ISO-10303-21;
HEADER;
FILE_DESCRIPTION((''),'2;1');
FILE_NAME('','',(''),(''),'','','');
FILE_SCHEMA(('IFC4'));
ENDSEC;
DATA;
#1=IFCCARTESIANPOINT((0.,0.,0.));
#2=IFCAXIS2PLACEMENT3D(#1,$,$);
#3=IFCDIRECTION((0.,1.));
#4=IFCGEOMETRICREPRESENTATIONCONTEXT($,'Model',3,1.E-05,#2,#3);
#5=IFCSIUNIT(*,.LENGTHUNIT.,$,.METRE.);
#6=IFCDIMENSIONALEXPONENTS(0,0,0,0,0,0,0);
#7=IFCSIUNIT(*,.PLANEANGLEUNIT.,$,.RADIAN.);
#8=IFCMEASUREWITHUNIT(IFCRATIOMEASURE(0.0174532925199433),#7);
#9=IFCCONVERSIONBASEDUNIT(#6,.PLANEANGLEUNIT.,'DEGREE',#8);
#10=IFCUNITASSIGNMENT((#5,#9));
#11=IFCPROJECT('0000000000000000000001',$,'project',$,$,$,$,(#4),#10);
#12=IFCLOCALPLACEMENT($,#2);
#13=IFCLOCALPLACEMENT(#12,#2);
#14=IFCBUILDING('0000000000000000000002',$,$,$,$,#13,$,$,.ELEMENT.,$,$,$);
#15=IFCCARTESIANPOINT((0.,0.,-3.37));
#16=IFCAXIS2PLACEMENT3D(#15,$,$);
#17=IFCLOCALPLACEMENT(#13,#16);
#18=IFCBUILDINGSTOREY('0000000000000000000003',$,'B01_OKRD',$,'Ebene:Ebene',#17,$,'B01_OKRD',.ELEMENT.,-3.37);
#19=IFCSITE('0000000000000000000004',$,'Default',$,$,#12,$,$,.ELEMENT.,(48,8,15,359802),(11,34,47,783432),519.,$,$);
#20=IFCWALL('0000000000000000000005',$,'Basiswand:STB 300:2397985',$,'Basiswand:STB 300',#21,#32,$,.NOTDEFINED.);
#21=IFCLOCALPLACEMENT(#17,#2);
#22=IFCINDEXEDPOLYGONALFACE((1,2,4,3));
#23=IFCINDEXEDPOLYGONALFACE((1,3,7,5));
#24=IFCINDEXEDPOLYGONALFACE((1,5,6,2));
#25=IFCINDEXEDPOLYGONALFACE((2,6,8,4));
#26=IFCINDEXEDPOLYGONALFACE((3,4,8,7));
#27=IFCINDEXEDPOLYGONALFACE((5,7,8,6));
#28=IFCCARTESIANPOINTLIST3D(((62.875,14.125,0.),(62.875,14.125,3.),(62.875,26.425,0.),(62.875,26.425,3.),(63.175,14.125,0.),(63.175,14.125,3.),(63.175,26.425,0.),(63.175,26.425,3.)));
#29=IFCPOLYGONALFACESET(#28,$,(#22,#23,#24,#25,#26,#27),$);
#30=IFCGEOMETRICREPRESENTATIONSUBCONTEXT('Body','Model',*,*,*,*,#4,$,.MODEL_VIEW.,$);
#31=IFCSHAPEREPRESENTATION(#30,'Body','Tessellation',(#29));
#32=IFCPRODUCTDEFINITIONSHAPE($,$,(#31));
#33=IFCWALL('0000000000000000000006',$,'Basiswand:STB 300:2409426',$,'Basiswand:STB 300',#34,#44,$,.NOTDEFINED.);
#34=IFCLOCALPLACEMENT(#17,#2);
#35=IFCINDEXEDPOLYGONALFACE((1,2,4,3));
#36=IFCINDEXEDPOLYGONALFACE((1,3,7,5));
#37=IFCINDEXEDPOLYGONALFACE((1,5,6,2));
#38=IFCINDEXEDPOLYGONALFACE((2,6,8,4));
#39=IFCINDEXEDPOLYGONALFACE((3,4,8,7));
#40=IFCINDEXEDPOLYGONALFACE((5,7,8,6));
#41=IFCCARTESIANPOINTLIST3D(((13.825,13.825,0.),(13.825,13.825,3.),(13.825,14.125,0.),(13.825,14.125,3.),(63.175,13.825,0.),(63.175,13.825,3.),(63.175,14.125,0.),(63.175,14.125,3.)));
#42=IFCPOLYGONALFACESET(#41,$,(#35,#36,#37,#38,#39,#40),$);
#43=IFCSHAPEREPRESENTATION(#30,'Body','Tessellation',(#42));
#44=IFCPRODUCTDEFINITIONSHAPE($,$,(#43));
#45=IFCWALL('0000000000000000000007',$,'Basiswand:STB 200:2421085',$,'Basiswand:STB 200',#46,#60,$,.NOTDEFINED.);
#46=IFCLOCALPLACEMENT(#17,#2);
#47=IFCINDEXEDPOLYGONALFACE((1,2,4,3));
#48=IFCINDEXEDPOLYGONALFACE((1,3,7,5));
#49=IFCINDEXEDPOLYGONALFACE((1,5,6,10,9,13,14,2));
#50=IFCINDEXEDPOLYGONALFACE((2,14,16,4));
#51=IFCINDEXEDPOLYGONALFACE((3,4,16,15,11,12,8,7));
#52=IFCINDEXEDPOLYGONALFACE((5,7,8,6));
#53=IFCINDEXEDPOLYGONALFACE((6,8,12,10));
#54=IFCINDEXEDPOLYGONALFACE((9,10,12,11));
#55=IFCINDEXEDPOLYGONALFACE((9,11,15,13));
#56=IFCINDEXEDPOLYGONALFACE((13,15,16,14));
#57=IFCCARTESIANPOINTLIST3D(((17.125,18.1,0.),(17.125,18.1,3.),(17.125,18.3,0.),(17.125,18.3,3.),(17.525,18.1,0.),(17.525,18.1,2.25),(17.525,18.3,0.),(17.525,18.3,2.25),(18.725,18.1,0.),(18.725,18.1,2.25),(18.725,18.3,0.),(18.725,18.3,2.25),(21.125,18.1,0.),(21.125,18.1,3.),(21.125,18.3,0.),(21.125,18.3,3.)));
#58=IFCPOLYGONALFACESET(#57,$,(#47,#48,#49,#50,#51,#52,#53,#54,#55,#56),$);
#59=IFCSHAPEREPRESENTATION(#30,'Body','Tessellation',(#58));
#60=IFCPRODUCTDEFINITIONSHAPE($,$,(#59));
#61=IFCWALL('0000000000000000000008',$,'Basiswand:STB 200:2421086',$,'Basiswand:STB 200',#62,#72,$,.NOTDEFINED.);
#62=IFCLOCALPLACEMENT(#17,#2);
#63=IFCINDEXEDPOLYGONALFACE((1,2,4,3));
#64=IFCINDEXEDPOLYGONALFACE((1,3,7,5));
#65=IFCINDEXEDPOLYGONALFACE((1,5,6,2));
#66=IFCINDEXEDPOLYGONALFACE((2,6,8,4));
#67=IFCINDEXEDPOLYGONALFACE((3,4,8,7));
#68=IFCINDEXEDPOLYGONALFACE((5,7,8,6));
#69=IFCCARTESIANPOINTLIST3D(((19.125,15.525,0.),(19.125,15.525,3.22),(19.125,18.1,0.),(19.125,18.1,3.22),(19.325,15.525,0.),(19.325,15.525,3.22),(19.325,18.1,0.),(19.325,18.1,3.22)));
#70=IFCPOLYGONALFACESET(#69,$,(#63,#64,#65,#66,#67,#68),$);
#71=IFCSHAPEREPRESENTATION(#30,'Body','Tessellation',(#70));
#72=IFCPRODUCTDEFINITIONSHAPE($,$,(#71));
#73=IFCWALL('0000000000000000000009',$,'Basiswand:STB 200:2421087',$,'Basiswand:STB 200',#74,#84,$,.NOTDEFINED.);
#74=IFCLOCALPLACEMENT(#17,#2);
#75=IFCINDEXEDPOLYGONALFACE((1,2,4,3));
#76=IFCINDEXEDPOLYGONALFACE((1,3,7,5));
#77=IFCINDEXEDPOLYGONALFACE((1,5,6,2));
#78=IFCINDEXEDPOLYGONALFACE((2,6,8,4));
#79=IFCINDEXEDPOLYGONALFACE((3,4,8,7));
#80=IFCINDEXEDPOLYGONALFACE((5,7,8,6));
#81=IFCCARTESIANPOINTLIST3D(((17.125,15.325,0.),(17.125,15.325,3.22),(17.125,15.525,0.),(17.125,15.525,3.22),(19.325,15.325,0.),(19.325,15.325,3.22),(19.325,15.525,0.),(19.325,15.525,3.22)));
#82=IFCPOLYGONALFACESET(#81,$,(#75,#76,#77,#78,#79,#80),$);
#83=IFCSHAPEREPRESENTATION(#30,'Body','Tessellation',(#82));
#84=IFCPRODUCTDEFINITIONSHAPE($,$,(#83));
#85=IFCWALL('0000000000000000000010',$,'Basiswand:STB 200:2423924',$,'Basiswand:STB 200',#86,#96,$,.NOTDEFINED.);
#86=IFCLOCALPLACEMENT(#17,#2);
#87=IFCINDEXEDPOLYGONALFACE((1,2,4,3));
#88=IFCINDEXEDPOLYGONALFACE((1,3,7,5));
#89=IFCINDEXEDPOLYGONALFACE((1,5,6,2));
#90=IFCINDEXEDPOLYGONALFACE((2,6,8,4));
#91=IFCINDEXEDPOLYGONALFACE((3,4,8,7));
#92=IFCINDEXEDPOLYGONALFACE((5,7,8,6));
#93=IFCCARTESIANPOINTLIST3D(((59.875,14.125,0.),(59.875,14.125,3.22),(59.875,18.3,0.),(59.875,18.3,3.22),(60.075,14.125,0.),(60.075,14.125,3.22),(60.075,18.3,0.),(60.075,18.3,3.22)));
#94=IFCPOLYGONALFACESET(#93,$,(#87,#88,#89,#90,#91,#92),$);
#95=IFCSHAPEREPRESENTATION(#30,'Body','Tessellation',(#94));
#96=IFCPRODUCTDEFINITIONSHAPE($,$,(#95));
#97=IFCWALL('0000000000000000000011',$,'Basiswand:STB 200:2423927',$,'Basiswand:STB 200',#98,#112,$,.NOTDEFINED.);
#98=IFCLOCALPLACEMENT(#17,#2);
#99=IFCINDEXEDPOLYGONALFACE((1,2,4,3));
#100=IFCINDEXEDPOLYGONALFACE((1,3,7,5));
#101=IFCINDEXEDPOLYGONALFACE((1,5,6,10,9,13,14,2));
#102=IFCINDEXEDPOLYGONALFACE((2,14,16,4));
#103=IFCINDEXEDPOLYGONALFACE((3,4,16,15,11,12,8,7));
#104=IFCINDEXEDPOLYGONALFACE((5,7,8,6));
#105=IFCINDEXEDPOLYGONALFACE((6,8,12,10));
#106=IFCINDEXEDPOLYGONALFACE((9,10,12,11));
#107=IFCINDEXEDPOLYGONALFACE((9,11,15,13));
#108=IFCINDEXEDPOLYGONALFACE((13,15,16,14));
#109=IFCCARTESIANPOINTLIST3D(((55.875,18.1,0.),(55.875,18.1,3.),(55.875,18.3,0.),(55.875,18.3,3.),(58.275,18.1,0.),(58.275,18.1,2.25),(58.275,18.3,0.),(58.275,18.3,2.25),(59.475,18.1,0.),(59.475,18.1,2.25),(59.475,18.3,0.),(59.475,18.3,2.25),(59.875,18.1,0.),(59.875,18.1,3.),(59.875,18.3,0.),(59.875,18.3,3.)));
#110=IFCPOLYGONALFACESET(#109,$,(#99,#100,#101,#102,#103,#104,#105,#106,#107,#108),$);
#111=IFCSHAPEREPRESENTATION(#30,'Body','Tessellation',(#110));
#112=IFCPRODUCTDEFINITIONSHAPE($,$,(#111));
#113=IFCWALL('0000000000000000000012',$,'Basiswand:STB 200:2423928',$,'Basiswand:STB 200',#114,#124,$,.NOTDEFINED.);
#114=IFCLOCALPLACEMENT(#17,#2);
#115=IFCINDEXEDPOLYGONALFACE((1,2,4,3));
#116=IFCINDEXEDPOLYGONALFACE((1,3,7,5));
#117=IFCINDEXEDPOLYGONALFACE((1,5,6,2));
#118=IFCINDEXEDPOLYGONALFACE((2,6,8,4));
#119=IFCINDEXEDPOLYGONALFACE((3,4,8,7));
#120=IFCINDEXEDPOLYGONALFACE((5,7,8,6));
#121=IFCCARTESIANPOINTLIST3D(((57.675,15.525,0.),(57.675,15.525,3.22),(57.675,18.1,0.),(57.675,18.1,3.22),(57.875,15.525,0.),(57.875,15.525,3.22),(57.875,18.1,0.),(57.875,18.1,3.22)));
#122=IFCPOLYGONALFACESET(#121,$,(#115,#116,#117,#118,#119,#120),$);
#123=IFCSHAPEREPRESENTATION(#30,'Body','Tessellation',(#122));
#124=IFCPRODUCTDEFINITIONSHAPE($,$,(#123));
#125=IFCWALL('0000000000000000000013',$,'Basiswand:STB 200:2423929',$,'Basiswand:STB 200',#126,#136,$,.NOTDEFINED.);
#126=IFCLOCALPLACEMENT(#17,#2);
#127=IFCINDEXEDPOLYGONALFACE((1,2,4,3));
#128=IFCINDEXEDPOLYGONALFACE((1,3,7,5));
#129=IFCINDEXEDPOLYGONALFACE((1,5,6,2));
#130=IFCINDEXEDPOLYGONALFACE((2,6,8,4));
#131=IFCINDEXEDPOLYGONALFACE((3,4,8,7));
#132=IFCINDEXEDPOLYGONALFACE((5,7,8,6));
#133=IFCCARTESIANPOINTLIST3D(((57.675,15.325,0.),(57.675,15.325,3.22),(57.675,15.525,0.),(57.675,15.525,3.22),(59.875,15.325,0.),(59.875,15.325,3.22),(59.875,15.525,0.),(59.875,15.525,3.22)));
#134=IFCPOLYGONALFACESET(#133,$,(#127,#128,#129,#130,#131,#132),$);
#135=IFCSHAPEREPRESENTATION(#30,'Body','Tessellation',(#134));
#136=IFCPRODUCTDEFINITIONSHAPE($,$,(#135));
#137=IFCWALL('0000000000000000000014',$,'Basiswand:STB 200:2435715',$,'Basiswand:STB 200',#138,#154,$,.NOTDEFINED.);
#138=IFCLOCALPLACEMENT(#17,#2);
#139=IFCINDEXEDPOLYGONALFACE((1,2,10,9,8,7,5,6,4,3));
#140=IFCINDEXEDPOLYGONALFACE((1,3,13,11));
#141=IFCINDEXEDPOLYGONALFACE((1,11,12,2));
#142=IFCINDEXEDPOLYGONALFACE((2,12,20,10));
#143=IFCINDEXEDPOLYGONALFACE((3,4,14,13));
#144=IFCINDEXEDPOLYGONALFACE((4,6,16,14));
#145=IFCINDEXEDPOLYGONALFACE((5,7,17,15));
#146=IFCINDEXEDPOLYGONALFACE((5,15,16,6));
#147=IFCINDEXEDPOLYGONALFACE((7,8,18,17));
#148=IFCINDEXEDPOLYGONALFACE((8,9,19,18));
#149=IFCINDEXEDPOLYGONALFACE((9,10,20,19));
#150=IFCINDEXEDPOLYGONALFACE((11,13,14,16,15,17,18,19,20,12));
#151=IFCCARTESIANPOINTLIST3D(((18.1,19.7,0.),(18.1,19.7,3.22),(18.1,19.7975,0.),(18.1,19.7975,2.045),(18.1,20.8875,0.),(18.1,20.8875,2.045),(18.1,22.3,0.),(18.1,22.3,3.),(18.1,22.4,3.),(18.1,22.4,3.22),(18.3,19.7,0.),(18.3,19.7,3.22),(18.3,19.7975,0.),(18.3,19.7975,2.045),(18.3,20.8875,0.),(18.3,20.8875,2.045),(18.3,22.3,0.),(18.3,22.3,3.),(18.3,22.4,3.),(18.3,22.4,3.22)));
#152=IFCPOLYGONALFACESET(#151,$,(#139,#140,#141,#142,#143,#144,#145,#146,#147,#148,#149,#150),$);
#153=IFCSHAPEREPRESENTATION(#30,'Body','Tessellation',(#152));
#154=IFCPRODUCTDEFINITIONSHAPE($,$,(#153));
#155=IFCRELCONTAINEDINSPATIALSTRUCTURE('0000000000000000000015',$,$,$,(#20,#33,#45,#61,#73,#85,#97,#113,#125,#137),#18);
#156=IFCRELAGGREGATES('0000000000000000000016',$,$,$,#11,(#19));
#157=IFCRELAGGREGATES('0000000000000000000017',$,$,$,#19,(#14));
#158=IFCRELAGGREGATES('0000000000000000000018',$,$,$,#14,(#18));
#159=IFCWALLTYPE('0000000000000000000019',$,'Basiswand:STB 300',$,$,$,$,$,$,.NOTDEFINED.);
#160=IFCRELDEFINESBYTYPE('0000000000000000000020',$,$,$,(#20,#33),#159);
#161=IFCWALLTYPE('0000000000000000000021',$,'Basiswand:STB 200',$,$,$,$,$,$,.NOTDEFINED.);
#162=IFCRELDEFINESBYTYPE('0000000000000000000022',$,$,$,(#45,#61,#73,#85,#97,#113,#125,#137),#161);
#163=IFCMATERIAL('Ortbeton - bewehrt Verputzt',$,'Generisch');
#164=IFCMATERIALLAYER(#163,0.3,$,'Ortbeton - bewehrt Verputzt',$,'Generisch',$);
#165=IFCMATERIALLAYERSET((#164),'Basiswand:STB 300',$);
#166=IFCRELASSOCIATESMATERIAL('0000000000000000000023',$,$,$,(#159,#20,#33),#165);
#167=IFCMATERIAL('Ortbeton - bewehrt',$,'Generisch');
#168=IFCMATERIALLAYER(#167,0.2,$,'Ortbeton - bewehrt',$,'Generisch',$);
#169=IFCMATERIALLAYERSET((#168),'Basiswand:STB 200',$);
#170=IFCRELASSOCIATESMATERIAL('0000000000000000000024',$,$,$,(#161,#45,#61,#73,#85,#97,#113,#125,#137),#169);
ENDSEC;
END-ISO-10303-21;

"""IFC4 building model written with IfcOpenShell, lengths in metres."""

from ifc_helpers import new_model, entity, si_unit, converted_unit, direction, frame, frame_2d, origin, place, context, subcontext, project, spatial, polyline, rectangle, extrude, clip, bounded_halfspace, material, layer, layer_set, layer_usage, type_object, element, save


model = new_model("IFC4")

# Units and contexts
model_context = context("Model", 3, precision=1e-05, world=origin(), true_north=direction((0.0, 1.0)))
body_context = subcontext(model_context, "Body", "Model", "MODEL_VIEW")
ifc_project = project(units=[si_unit("LENGTHUNIT", "METRE"), converted_unit("PLANEANGLEUNIT", "DEGREE", entity("IfcRatioMeasure", 0.0174532925199433), si_unit("PLANEANGLEUNIT", "RADIAN"), dimensions=[0, 0, 0, 0, 0, 0, 0])], contexts=[model_context])

# Site, building, storey
site_placement = place(None, frame((0.0, 0.0, 0.0)))
site = spatial("IfcSite", under=ifc_project, at=site_placement, Name="Default", CompositionType="ELEMENT", RefLatitude=(48, 8, 15, 359802), RefLongitude=(11, 34, 47, 783432), RefElevation=519.0)
building_placement = place(site_placement, origin())
building = spatial("IfcBuilding", under=site, at=building_placement, CompositionType="ELEMENT")
storey_placement = place(building_placement, frame((0.0, 0.0, -3.37)))
storey = spatial("IfcBuildingStorey", under=building, at=storey_placement, Name="B01_OKRD", ObjectType="Ebene:Ebene", LongName="B01_OKRD", CompositionType="ELEMENT", Elevation=-3.37)

# Walls
ifc_material_1 = material(Name="Ortbeton - bewehrt Verputzt", Category="Generisch")
ifc_layer_1 = layer(ifc_material_1, 0.3, Name="Ortbeton - bewehrt Verputzt", Category="Generisch")
ifc_layer_set_1 = layer_set([ifc_layer_1], Name="Basiswand:STB 300")
ifc_layer_usage_1 = layer_usage(ifc_layer_set_1, "AXIS2", "NEGATIVE", 0.15)
wall_type_1 = type_object("IfcWallType", Name="Basiswand:STB 300", PredefinedType="NOTDEFINED", material=ifc_layer_set_1)
wall_1_placement = place(storey_placement, frame((63.025, 26.425, 0.0), z_axis=(0.0, 0.0, 1.0), x_axis=(0.0, -1.0, 0.0)))
element("IfcWall", 1, at=wall_1_placement, inside=storey, type_object=wall_type_1, material=ifc_layer_usage_1, Name="Basiswand:STB 300:2397985", ObjectType="Basiswand:STB 300", PredefinedType="NOTDEFINED", context=body_context, shape_type="SweptSolid", body=[
    extrude(rectangle(XDim=12.3, YDim=0.3, at=frame_2d((6.15, 0.0), x_axis=(-1.0, 0.0))), origin(), (0.0, 0.0, 1.0), 3.0),
])
ifc_layer_usage_2 = layer_usage(ifc_layer_set_1, "AXIS2", "NEGATIVE", 0.15)
wall_2_placement = place(storey_placement, frame((63.175, 13.975, 0.0), z_axis=(0.0, 0.0, 1.0), x_axis=(-1.0, 0.0, 0.0)))
element("IfcWall", 2, at=wall_2_placement, inside=storey, type_object=wall_type_1, material=ifc_layer_usage_2, Name="Basiswand:STB 300:2409426", ObjectType="Basiswand:STB 300", PredefinedType="NOTDEFINED", context=body_context, shape_type="SweptSolid", body=[
    extrude(rectangle(XDim=49.35, YDim=0.3, at=frame_2d((24.675, 0.0), x_axis=(-1.0, 0.0))), origin(), (0.0, 0.0, 1.0), 3.0),
])

# Wall, opening
ifc_material_2 = material(Name="Ortbeton - bewehrt", Category="Generisch")
ifc_layer_2 = layer(ifc_material_2, 0.2, Name="Ortbeton - bewehrt", Category="Generisch")
ifc_layer_set_2 = layer_set([ifc_layer_2], Name="Basiswand:STB 200")
ifc_layer_usage_3 = layer_usage(ifc_layer_set_2, "AXIS2", "POSITIVE", -0.1)
wall_type_2 = type_object("IfcWallType", Name="Basiswand:STB 200", PredefinedType="NOTDEFINED", material=ifc_layer_set_2)
wall_3_placement = place(storey_placement, frame((17.125, 18.2, 0.0)))
wall_3 = element("IfcWall", 3, at=wall_3_placement, inside=storey, type_object=wall_type_2, material=ifc_layer_usage_3, Name="Basiswand:STB 200:2421085", ObjectType="Basiswand:STB 200", PredefinedType="NOTDEFINED", context=body_context, shape_type="SweptSolid", body=[
    extrude(rectangle(XDim=4.0, YDim=0.2, at=frame_2d((2.0, 0.0), x_axis=(-1.0, 0.0))), origin(), (0.0, 0.0, 1.0), 3.0),
])
opening_1_placement = place(wall_3_placement, frame((0.4, -0.1, -0.03)))
element("IfcOpeningElement", 4, at=opening_1_placement, cuts=wall_3, ObjectType="Opening", PredefinedType="OPENING", context=body_context, shape_type="SweptSolid", body=[
    extrude(rectangle(XDim=2.28, YDim=1.2, at=frame_2d((1.14, 0.6), x_axis=(1.0, 0.0))), frame((0.0, 0.0, 0.0), z_axis=(0.0, 1.0, 0.0), x_axis=(0.0, 0.0, 1.0)), (0.0, 0.0, 1.0), 0.2),
])

# Walls
ifc_layer_usage_4 = layer_usage(ifc_layer_set_2, "AXIS2", "NEGATIVE", 0.1)
wall_4_placement = place(storey_placement, frame((19.225, 15.525, 0.0), z_axis=(0.0, 0.0, 1.0), x_axis=(0.0, 1.0, 0.0)))
element("IfcWall", 5, at=wall_4_placement, inside=storey, type_object=wall_type_2, material=ifc_layer_usage_4, Name="Basiswand:STB 200:2421086", ObjectType="Basiswand:STB 200", PredefinedType="NOTDEFINED", context=body_context, shape_type="SweptSolid", body=[
    extrude(rectangle(XDim=2.575, YDim=0.2, at=frame_2d((1.2875, 0.0), x_axis=(-1.0, 0.0))), origin(), (0.0, 0.0, 1.0), 3.22),
])
ifc_layer_usage_5 = layer_usage(ifc_layer_set_2, "AXIS2", "POSITIVE", -0.1)
wall_5_placement = place(storey_placement, frame((17.125, 15.425, 0.0)))
element("IfcWall", 6, at=wall_5_placement, inside=storey, type_object=wall_type_2, material=ifc_layer_usage_5, Name="Basiswand:STB 200:2421087", ObjectType="Basiswand:STB 200", PredefinedType="NOTDEFINED", context=body_context, shape_type="SweptSolid", body=[
    extrude(rectangle(XDim=2.2, YDim=0.2, at=frame_2d((1.1, 0.0), x_axis=(-1.0, 0.0))), origin(), (0.0, 0.0, 1.0), 3.22),
])
ifc_layer_usage_6 = layer_usage(ifc_layer_set_2, "AXIS2", "NEGATIVE", 0.1)
wall_6_placement = place(storey_placement, frame((59.975, 14.125, 0.0), z_axis=(0.0, 0.0, 1.0), x_axis=(0.0, 1.0, 0.0)))
element("IfcWall", 7, at=wall_6_placement, inside=storey, type_object=wall_type_2, material=ifc_layer_usage_6, Name="Basiswand:STB 200:2423924", ObjectType="Basiswand:STB 200", PredefinedType="NOTDEFINED", context=body_context, shape_type="SweptSolid", body=[
    extrude(rectangle(XDim=4.175, YDim=0.2, at=frame_2d((2.0875, 0.0), x_axis=(-1.0, 0.0))), origin(), (0.0, 0.0, 1.0), 3.22),
])

# Wall, opening
ifc_layer_usage_7 = layer_usage(ifc_layer_set_2, "AXIS2", "NEGATIVE", 0.1)
wall_7_placement = place(storey_placement, frame((59.875, 18.2, 0.0), z_axis=(0.0, 0.0, 1.0), x_axis=(-1.0, 0.0, 0.0)))
wall_7 = element("IfcWall", 8, at=wall_7_placement, inside=storey, type_object=wall_type_2, material=ifc_layer_usage_7, Name="Basiswand:STB 200:2423927", ObjectType="Basiswand:STB 200", PredefinedType="NOTDEFINED", context=body_context, shape_type="SweptSolid", body=[
    extrude(rectangle(XDim=4.0, YDim=0.2, at=frame_2d((2.0, 0.0), x_axis=(-1.0, 0.0))), origin(), (0.0, 0.0, 1.0), 3.0),
])
opening_2_placement = place(wall_7_placement, frame((1.6, 0.1, -0.03)))
element("IfcOpeningElement", 9, at=opening_2_placement, cuts=wall_7, ObjectType="Opening", PredefinedType="OPENING", context=body_context, shape_type="SweptSolid", body=[
    extrude(rectangle(XDim=2.28, YDim=1.2, at=frame_2d((1.14, 0.6), x_axis=(1.0, 0.0))), frame((0.0, 0.0, 0.0), z_axis=(0.0, -1.0, 0.0), x_axis=(0.0, 0.0, 1.0)), (0.0, 0.0, 1.0), 0.2),
])

# Walls
ifc_layer_usage_8 = layer_usage(ifc_layer_set_2, "AXIS2", "POSITIVE", -0.1)
wall_8_placement = place(storey_placement, frame((57.775, 15.525, 0.0), z_axis=(0.0, 0.0, 1.0), x_axis=(0.0, 1.0, 0.0)))
element("IfcWall", 10, at=wall_8_placement, inside=storey, type_object=wall_type_2, material=ifc_layer_usage_8, Name="Basiswand:STB 200:2423928", ObjectType="Basiswand:STB 200", PredefinedType="NOTDEFINED", context=body_context, shape_type="SweptSolid", body=[
    extrude(rectangle(XDim=2.575, YDim=0.2, at=frame_2d((1.2875, 0.0), x_axis=(-1.0, 0.0))), origin(), (0.0, 0.0, 1.0), 3.22),
])
ifc_layer_usage_9 = layer_usage(ifc_layer_set_2, "AXIS2", "NEGATIVE", 0.1)
wall_9_placement = place(storey_placement, frame((59.875, 15.425, 0.0), z_axis=(0.0, 0.0, 1.0), x_axis=(-1.0, 0.0, 0.0)))
element("IfcWall", 11, at=wall_9_placement, inside=storey, type_object=wall_type_2, material=ifc_layer_usage_9, Name="Basiswand:STB 200:2423929", ObjectType="Basiswand:STB 200", PredefinedType="NOTDEFINED", context=body_context, shape_type="SweptSolid", body=[
    extrude(rectangle(XDim=2.2, YDim=0.2, at=frame_2d((1.1, 0.0), x_axis=(-1.0, 0.0))), origin(), (0.0, 0.0, 1.0), 3.22),
])

# Wall, opening
ifc_layer_usage_10 = layer_usage(ifc_layer_set_2, "AXIS2", "POSITIVE", -0.1)
wall_10_placement = place(storey_placement, frame((18.2, 19.7, 0.0), z_axis=(0.0, 0.0, 1.0), x_axis=(0.0, 1.0, 0.0)))
wall_10 = element("IfcWall", 12, at=wall_10_placement, inside=storey, type_object=wall_type_2, material=ifc_layer_usage_10, Name="Basiswand:STB 200:2435715", ObjectType="Basiswand:STB 200", PredefinedType="NOTDEFINED", context=body_context, shape_type="Clipping", body=[
    clip(clip(extrude(rectangle(XDim=2.7, YDim=0.2, at=frame_2d((1.35, 0.0), x_axis=(-1.0, 0.0))), origin(), (0.0, 0.0, 1.0), 3.22), bounded_halfspace(frame((2.6, 0.1, 3.0), z_axis=(-1.0, 0.0, 0.0), x_axis=(0.0, -1.0, 0.0)), True, frame((2.6, 0.1, 3.0), z_axis=(-1.0, 0.0, 0.0), x_axis=(0.0, -1.0, 0.0)), polyline([(0.0, 0.0), (0.0, -3.0), (0.2, -3.0), (0.2, 0.0), (0.0, 0.0)]))), bounded_halfspace(frame((2.6, -0.1, 3.0)), True, frame((2.6, -0.1, 3.0)), polyline([(0.0, 0.0), (0.1, 0.0), (0.1, 0.2), (0.0, 0.2), (0.0, 0.0)]))),
])
opening_3_placement = place(wall_10_placement, frame((0.0975, -0.1, -0.18)))
element("IfcOpeningElement", 13, at=opening_3_placement, cuts=wall_10, ObjectType="Opening", PredefinedType="OPENING", context=body_context, shape_type="SweptSolid", body=[
    extrude(rectangle(XDim=2.225, YDim=1.09, at=frame_2d((1.1125, 0.545), x_axis=(-1.0, 0.0))), frame((0.0, 0.0, 0.0), z_axis=(0.0, 1.0, 0.0), x_axis=(0.0, 0.0, 1.0)), (0.0, 0.0, 1.0), 0.2),
])

save(model, "model.ifc")
